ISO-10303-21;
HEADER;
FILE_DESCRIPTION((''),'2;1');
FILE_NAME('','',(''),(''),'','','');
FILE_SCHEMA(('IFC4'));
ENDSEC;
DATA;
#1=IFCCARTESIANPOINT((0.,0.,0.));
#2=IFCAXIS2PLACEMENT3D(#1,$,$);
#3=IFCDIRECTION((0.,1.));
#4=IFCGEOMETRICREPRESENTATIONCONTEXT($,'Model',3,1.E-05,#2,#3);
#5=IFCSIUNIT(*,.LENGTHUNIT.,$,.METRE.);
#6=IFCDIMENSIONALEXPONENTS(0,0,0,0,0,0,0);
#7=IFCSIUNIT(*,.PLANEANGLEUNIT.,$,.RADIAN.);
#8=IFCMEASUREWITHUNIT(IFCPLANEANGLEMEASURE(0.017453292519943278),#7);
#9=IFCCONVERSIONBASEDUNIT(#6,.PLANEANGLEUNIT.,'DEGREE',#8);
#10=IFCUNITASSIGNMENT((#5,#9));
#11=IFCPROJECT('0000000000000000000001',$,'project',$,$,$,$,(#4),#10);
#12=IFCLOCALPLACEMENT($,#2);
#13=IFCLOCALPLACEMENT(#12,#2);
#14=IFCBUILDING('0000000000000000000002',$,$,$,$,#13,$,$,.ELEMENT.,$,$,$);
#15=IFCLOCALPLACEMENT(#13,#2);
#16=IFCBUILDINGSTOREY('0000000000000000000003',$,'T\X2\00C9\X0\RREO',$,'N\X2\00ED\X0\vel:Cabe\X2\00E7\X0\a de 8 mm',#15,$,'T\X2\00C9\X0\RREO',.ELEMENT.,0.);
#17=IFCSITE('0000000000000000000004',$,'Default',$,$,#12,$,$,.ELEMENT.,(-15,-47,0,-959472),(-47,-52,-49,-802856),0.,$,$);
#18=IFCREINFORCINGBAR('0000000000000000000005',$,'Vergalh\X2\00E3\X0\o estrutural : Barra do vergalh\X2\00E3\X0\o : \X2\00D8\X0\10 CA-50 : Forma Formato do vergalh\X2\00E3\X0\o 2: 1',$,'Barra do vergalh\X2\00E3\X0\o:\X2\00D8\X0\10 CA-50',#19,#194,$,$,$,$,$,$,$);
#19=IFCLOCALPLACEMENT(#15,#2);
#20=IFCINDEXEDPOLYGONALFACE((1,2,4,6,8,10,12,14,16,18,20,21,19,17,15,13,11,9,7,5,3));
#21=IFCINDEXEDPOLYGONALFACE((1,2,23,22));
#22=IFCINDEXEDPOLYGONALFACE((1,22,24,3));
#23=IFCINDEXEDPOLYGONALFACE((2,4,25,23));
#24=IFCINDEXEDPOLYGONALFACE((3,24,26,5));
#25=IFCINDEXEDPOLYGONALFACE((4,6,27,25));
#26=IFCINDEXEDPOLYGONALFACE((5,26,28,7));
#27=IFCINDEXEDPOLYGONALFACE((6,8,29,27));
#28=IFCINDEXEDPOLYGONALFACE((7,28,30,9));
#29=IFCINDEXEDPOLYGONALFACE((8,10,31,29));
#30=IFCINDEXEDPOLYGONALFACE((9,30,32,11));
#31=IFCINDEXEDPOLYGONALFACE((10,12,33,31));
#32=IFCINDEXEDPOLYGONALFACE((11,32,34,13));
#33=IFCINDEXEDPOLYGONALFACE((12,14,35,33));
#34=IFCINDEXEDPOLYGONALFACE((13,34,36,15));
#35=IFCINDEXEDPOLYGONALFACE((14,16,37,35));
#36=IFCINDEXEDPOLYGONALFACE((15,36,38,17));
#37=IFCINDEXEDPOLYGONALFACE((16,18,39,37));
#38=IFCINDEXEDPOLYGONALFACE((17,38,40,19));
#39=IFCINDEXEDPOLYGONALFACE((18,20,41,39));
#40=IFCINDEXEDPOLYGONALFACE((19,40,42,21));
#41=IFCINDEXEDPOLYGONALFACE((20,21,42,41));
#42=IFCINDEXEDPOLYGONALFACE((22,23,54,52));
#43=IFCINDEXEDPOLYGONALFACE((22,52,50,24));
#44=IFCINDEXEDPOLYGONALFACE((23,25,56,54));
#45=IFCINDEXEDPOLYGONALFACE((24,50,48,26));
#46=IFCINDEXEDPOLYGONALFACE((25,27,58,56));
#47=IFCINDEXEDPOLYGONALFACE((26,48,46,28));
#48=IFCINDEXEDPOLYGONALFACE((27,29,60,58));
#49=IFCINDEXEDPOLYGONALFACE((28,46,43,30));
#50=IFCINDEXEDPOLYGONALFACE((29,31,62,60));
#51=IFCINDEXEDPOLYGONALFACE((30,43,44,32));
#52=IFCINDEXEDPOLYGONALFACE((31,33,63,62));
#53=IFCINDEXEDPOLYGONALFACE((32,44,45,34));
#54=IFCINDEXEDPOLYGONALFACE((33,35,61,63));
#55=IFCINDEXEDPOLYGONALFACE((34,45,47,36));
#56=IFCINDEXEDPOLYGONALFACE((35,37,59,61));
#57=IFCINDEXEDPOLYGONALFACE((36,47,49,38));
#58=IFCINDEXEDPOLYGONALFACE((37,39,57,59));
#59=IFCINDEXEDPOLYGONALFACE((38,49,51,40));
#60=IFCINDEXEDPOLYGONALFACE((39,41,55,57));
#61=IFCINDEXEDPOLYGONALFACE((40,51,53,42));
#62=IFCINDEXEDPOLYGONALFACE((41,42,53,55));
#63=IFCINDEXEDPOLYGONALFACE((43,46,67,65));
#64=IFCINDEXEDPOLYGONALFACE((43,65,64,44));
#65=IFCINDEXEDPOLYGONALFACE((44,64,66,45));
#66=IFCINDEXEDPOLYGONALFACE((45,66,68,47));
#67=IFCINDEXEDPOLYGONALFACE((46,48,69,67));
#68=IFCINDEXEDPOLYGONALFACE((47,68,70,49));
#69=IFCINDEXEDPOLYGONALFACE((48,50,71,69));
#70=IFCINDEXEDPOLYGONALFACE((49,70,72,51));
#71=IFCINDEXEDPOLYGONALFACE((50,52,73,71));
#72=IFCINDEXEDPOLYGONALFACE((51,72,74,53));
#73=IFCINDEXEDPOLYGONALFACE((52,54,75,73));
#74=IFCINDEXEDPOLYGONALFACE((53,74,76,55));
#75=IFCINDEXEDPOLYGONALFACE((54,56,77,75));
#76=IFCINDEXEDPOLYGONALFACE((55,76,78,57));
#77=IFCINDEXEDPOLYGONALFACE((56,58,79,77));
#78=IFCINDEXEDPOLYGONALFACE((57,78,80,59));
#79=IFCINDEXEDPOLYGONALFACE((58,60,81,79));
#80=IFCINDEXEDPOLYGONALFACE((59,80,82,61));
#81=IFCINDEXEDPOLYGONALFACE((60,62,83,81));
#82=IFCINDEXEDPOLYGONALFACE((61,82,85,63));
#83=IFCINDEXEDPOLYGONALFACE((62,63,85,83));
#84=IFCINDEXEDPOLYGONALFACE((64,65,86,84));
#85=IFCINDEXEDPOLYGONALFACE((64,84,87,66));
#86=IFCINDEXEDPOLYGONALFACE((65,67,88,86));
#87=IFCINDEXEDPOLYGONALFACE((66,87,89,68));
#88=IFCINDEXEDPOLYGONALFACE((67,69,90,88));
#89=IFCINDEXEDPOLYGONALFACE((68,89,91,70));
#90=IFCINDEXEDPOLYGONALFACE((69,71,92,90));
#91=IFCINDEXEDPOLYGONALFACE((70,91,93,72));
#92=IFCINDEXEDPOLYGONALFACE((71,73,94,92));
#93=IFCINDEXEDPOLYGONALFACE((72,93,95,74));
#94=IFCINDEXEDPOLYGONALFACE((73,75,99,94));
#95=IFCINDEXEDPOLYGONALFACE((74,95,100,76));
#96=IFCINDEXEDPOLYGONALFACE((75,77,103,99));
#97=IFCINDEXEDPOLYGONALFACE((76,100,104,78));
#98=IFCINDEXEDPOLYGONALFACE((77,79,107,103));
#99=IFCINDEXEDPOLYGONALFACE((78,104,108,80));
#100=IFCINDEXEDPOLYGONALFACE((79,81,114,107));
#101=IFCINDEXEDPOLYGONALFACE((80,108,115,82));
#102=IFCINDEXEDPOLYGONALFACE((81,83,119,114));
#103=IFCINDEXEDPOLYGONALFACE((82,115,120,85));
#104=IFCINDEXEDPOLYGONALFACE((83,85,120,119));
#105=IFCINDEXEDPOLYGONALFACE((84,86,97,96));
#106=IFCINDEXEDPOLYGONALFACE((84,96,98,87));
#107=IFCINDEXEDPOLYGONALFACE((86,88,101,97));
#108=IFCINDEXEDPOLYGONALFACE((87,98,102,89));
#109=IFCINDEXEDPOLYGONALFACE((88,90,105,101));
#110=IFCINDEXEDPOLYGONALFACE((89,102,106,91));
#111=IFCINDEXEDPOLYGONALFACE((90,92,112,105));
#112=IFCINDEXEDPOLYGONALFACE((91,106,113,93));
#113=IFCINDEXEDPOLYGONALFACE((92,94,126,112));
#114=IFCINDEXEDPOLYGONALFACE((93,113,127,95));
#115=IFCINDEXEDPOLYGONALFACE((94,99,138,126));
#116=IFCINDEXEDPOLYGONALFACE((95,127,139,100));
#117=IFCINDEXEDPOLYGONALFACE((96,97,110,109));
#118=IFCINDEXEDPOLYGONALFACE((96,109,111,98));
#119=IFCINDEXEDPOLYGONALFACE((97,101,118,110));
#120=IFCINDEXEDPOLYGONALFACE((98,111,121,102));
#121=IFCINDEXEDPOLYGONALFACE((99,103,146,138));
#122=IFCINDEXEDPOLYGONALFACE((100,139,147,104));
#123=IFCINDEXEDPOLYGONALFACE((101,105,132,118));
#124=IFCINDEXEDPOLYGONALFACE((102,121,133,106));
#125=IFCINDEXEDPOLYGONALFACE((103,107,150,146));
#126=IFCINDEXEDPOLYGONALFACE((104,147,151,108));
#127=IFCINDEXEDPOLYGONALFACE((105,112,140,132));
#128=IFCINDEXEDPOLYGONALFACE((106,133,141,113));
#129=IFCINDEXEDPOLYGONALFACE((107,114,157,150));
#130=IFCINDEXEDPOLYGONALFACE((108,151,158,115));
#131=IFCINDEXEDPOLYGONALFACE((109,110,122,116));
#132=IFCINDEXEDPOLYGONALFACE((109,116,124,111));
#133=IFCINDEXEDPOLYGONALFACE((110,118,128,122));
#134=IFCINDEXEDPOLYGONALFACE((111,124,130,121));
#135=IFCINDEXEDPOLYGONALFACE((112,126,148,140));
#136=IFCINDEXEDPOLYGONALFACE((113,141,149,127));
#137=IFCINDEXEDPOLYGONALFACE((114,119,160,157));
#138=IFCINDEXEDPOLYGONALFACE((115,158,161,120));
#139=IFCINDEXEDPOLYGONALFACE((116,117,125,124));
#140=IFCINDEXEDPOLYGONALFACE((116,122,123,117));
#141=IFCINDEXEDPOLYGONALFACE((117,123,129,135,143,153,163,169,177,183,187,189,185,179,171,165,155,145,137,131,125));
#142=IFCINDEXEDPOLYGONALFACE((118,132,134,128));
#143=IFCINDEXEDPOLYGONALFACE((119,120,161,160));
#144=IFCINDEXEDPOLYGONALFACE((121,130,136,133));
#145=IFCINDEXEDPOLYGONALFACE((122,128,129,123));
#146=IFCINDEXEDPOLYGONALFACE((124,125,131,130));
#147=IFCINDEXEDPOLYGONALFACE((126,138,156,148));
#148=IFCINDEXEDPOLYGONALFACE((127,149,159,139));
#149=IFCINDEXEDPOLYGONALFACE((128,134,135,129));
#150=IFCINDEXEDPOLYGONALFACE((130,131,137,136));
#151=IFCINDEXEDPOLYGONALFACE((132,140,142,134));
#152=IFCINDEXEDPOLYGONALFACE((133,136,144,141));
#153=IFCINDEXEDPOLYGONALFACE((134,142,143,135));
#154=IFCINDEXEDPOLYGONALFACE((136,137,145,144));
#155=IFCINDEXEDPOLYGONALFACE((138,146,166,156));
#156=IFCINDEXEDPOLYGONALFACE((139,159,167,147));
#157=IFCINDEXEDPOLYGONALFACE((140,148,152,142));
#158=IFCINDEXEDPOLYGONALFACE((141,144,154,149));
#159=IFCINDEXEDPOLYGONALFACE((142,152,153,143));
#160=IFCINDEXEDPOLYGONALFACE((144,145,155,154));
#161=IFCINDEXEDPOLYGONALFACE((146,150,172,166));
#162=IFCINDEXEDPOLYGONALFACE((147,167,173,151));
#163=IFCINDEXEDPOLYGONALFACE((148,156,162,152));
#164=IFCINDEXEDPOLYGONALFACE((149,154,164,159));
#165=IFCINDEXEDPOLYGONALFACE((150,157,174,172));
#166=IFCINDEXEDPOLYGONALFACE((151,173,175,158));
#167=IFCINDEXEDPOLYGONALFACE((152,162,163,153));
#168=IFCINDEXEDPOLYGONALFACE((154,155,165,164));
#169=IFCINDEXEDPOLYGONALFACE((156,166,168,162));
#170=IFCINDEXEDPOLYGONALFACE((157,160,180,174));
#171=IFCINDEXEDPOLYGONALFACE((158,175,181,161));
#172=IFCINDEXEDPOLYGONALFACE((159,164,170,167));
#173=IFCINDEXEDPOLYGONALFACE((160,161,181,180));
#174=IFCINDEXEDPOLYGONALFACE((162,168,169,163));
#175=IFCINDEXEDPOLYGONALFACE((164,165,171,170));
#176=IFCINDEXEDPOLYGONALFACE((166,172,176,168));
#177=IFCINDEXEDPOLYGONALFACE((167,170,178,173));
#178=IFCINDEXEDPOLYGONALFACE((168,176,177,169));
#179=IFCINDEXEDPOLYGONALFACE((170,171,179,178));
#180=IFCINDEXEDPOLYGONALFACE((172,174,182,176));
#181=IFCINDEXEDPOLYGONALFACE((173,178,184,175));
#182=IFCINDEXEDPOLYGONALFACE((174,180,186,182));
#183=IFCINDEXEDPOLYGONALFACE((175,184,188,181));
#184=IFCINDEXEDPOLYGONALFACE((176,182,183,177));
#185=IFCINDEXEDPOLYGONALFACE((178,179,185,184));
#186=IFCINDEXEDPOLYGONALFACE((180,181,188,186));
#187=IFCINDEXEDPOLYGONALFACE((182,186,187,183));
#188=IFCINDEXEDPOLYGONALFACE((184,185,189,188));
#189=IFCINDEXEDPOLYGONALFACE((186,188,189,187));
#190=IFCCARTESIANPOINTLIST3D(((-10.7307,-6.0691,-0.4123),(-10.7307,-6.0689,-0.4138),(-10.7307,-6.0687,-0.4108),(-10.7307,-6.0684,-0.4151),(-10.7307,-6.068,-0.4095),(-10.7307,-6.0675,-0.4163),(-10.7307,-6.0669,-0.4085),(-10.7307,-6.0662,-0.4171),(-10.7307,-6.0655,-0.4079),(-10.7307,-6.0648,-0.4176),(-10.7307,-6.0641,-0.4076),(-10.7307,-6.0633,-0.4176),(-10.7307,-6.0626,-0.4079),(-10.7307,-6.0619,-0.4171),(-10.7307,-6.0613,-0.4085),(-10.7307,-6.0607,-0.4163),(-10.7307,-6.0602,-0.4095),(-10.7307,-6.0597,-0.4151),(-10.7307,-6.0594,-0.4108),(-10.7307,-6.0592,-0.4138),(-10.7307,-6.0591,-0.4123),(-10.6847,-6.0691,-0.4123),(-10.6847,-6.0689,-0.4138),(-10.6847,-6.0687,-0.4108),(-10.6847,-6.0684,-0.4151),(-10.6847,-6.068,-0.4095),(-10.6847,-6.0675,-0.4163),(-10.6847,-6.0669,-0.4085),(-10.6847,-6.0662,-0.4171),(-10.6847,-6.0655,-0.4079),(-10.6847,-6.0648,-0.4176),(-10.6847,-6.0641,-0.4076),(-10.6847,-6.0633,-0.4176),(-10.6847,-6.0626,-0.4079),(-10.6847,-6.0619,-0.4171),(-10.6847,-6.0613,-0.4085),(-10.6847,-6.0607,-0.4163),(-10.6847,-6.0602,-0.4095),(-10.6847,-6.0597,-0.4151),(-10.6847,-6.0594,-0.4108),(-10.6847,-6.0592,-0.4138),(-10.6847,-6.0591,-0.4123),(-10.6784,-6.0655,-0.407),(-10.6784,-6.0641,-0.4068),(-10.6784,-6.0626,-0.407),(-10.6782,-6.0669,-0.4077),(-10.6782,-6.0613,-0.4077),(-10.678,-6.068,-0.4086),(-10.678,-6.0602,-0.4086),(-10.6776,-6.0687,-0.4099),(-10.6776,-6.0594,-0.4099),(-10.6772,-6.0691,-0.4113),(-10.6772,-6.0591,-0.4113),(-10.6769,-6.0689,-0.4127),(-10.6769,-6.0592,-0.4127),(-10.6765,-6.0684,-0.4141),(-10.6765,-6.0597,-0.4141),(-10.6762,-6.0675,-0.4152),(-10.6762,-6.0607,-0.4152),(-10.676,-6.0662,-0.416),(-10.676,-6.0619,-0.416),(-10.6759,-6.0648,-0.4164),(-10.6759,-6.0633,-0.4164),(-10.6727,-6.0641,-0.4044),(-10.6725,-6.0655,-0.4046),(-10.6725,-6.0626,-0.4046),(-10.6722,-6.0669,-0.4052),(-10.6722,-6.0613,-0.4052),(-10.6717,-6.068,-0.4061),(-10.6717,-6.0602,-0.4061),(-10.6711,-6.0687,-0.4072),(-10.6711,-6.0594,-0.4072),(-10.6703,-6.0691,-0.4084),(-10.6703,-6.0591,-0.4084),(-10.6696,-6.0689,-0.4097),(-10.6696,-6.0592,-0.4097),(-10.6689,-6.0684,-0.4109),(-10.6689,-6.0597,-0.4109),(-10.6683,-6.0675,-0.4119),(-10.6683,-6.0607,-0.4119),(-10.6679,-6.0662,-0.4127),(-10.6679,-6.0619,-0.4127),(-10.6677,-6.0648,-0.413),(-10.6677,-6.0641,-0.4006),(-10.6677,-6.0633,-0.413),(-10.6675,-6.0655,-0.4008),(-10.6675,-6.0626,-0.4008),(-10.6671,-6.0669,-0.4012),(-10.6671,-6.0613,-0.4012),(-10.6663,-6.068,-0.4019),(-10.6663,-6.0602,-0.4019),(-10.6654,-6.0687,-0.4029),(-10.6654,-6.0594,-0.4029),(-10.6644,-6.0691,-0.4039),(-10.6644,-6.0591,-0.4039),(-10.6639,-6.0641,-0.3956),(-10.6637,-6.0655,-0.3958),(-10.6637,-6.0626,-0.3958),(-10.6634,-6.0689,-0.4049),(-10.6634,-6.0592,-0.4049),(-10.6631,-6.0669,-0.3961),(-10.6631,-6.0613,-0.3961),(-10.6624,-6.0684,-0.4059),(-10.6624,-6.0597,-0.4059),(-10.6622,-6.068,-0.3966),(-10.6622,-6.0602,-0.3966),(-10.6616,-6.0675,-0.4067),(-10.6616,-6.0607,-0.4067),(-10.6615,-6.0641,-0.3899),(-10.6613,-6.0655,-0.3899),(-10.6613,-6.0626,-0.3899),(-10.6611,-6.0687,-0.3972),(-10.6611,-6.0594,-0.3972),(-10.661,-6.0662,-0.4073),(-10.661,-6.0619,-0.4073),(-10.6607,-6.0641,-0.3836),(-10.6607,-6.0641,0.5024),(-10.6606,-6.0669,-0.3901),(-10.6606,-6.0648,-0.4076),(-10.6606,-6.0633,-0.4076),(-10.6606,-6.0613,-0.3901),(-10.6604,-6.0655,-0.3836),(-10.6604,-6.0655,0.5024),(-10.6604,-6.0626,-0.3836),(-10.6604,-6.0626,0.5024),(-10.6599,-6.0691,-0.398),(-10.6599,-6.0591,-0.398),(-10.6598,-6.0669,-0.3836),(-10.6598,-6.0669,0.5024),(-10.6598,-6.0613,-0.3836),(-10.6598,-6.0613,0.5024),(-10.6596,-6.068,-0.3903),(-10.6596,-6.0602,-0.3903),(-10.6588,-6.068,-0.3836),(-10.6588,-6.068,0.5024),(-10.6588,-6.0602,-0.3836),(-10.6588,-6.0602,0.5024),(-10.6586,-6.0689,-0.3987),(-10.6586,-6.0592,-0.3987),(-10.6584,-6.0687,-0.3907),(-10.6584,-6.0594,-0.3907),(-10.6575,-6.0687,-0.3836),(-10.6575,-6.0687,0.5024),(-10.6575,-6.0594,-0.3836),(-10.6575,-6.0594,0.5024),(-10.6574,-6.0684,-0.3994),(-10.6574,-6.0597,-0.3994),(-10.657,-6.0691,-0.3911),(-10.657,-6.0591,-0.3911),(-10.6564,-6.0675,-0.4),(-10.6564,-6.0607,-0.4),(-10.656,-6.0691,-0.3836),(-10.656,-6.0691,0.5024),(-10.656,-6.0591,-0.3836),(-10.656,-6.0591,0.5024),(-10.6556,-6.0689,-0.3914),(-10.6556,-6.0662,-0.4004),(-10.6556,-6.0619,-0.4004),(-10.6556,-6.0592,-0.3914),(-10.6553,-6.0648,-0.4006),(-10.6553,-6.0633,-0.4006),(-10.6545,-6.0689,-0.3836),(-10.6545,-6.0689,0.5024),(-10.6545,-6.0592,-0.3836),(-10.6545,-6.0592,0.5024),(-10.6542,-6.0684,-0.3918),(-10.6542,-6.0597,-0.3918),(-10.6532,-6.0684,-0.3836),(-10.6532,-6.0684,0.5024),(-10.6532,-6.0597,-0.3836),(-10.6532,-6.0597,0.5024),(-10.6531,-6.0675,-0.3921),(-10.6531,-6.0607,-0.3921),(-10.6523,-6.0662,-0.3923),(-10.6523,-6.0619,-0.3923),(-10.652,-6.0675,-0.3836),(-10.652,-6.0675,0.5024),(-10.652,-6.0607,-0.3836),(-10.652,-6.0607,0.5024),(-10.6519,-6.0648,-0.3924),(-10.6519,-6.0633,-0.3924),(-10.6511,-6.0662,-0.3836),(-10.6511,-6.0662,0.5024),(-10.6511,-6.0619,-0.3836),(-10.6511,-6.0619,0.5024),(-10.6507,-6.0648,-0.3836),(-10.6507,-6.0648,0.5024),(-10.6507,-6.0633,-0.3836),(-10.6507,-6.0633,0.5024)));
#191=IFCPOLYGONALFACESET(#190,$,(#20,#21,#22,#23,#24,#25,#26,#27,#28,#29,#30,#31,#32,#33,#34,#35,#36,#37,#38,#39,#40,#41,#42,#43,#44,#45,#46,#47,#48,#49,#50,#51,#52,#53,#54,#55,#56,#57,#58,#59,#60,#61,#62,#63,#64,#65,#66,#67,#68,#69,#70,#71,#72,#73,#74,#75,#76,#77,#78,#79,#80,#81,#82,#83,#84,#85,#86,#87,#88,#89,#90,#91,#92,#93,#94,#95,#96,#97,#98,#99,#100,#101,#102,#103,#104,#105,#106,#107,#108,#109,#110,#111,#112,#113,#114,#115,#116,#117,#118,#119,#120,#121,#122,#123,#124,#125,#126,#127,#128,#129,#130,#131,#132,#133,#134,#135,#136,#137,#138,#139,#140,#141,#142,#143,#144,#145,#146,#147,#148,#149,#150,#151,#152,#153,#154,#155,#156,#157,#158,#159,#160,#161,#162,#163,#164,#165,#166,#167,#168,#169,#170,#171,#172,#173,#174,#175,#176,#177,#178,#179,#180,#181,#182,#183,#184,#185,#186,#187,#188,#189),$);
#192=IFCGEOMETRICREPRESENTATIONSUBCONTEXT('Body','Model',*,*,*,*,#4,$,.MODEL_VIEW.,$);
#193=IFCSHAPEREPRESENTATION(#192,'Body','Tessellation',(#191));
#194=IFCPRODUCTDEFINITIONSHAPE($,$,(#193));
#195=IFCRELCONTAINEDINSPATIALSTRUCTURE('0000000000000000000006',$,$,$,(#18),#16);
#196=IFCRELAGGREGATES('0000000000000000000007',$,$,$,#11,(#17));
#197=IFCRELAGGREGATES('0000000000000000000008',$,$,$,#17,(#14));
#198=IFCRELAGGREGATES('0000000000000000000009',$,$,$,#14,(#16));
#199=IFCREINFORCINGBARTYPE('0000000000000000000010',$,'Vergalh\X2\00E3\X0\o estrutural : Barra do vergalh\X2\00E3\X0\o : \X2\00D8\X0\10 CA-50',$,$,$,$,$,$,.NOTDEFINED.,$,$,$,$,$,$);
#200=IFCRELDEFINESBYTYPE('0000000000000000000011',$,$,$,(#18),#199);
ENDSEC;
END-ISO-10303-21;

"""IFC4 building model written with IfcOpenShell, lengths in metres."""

from ifc_helpers import new_model, entity, si_unit, converted_unit, direction, origin, place, context, subcontext, project, spatial, type_object, element, save


model = new_model("IFC4")

# Units and contexts
model_context = context("Model", 3, precision=1e-05, world=origin(), true_north=direction((0.0, 1.0)))
body_context = subcontext(model_context, "Body", "Model", "MODEL_VIEW")
ifc_project = project(units=[si_unit("LENGTHUNIT", "METRE"), converted_unit("PLANEANGLEUNIT", "DEGREE", entity("IfcPlaneAngleMeasure", 0.017453292519943278), si_unit("PLANEANGLEUNIT", "RADIAN"), dimensions=[0, 0, 0, 0, 0, 0, 0])], contexts=[model_context])

# Site, building, storey
site_placement = place(None, origin())
site = spatial("IfcSite", under=ifc_project, at=site_placement, Name="Default", CompositionType="ELEMENT", RefLatitude=(-15, -47, 0, -959472), RefLongitude=(-47, -52, -49, -802856), RefElevation=0.0)
building_placement = place(site_placement, origin())
building = spatial("IfcBuilding", under=site, at=building_placement, CompositionType="ELEMENT")
storey_placement = place(building_placement, origin())
storey = spatial("IfcBuildingStorey", under=building, at=storey_placement, Name="TÉRREO", ObjectType="Nível:Cabeça de 8 mm", LongName="TÉRREO", CompositionType="ELEMENT", Elevation=0.0)

# Reinforcing bar
reinforcing_bar_type_1 = type_object("IfcReinforcingBarType", Name="Vergalhão estrutural : Barra do vergalhão : Ø10 CA-50", PredefinedType="NOTDEFINED")
reinforcing_bar_1_placement = place(storey_placement, origin())
element("IfcReinforcingBar", 1, at=reinforcing_bar_1_placement, inside=storey, type_object=reinforcing_bar_type_1, Name="Vergalhão estrutural : Barra do vergalhão : Ø10 CA-50 : Forma Formato do vergalhão 2: 1", ObjectType="Barra do vergalhão:Ø10 CA-50", context=body_context, shape_type="AdvancedSweptSolid", body=[
    entity("IfcSweptDiskSolid", entity("IfcIndexedPolyCurve", entity("IfcCartesianPointList3D", [[-10.7307, -6.0641, -0.4126], [-10.6847, -6.0641, -0.4126], [-10.6641, -6.0641, -0.4042], [-10.6557, -6.0641, -0.3836], [-10.6557, -6.0641, 0.5024]]), [entity("IfcLineIndex", [1, 2]), entity("IfcArcIndex", [2, 3, 4]), entity("IfcLineIndex", [4, 5])], False), 0.005, None, 0.0, 92.0),
])

save(model, "model.ifc")
